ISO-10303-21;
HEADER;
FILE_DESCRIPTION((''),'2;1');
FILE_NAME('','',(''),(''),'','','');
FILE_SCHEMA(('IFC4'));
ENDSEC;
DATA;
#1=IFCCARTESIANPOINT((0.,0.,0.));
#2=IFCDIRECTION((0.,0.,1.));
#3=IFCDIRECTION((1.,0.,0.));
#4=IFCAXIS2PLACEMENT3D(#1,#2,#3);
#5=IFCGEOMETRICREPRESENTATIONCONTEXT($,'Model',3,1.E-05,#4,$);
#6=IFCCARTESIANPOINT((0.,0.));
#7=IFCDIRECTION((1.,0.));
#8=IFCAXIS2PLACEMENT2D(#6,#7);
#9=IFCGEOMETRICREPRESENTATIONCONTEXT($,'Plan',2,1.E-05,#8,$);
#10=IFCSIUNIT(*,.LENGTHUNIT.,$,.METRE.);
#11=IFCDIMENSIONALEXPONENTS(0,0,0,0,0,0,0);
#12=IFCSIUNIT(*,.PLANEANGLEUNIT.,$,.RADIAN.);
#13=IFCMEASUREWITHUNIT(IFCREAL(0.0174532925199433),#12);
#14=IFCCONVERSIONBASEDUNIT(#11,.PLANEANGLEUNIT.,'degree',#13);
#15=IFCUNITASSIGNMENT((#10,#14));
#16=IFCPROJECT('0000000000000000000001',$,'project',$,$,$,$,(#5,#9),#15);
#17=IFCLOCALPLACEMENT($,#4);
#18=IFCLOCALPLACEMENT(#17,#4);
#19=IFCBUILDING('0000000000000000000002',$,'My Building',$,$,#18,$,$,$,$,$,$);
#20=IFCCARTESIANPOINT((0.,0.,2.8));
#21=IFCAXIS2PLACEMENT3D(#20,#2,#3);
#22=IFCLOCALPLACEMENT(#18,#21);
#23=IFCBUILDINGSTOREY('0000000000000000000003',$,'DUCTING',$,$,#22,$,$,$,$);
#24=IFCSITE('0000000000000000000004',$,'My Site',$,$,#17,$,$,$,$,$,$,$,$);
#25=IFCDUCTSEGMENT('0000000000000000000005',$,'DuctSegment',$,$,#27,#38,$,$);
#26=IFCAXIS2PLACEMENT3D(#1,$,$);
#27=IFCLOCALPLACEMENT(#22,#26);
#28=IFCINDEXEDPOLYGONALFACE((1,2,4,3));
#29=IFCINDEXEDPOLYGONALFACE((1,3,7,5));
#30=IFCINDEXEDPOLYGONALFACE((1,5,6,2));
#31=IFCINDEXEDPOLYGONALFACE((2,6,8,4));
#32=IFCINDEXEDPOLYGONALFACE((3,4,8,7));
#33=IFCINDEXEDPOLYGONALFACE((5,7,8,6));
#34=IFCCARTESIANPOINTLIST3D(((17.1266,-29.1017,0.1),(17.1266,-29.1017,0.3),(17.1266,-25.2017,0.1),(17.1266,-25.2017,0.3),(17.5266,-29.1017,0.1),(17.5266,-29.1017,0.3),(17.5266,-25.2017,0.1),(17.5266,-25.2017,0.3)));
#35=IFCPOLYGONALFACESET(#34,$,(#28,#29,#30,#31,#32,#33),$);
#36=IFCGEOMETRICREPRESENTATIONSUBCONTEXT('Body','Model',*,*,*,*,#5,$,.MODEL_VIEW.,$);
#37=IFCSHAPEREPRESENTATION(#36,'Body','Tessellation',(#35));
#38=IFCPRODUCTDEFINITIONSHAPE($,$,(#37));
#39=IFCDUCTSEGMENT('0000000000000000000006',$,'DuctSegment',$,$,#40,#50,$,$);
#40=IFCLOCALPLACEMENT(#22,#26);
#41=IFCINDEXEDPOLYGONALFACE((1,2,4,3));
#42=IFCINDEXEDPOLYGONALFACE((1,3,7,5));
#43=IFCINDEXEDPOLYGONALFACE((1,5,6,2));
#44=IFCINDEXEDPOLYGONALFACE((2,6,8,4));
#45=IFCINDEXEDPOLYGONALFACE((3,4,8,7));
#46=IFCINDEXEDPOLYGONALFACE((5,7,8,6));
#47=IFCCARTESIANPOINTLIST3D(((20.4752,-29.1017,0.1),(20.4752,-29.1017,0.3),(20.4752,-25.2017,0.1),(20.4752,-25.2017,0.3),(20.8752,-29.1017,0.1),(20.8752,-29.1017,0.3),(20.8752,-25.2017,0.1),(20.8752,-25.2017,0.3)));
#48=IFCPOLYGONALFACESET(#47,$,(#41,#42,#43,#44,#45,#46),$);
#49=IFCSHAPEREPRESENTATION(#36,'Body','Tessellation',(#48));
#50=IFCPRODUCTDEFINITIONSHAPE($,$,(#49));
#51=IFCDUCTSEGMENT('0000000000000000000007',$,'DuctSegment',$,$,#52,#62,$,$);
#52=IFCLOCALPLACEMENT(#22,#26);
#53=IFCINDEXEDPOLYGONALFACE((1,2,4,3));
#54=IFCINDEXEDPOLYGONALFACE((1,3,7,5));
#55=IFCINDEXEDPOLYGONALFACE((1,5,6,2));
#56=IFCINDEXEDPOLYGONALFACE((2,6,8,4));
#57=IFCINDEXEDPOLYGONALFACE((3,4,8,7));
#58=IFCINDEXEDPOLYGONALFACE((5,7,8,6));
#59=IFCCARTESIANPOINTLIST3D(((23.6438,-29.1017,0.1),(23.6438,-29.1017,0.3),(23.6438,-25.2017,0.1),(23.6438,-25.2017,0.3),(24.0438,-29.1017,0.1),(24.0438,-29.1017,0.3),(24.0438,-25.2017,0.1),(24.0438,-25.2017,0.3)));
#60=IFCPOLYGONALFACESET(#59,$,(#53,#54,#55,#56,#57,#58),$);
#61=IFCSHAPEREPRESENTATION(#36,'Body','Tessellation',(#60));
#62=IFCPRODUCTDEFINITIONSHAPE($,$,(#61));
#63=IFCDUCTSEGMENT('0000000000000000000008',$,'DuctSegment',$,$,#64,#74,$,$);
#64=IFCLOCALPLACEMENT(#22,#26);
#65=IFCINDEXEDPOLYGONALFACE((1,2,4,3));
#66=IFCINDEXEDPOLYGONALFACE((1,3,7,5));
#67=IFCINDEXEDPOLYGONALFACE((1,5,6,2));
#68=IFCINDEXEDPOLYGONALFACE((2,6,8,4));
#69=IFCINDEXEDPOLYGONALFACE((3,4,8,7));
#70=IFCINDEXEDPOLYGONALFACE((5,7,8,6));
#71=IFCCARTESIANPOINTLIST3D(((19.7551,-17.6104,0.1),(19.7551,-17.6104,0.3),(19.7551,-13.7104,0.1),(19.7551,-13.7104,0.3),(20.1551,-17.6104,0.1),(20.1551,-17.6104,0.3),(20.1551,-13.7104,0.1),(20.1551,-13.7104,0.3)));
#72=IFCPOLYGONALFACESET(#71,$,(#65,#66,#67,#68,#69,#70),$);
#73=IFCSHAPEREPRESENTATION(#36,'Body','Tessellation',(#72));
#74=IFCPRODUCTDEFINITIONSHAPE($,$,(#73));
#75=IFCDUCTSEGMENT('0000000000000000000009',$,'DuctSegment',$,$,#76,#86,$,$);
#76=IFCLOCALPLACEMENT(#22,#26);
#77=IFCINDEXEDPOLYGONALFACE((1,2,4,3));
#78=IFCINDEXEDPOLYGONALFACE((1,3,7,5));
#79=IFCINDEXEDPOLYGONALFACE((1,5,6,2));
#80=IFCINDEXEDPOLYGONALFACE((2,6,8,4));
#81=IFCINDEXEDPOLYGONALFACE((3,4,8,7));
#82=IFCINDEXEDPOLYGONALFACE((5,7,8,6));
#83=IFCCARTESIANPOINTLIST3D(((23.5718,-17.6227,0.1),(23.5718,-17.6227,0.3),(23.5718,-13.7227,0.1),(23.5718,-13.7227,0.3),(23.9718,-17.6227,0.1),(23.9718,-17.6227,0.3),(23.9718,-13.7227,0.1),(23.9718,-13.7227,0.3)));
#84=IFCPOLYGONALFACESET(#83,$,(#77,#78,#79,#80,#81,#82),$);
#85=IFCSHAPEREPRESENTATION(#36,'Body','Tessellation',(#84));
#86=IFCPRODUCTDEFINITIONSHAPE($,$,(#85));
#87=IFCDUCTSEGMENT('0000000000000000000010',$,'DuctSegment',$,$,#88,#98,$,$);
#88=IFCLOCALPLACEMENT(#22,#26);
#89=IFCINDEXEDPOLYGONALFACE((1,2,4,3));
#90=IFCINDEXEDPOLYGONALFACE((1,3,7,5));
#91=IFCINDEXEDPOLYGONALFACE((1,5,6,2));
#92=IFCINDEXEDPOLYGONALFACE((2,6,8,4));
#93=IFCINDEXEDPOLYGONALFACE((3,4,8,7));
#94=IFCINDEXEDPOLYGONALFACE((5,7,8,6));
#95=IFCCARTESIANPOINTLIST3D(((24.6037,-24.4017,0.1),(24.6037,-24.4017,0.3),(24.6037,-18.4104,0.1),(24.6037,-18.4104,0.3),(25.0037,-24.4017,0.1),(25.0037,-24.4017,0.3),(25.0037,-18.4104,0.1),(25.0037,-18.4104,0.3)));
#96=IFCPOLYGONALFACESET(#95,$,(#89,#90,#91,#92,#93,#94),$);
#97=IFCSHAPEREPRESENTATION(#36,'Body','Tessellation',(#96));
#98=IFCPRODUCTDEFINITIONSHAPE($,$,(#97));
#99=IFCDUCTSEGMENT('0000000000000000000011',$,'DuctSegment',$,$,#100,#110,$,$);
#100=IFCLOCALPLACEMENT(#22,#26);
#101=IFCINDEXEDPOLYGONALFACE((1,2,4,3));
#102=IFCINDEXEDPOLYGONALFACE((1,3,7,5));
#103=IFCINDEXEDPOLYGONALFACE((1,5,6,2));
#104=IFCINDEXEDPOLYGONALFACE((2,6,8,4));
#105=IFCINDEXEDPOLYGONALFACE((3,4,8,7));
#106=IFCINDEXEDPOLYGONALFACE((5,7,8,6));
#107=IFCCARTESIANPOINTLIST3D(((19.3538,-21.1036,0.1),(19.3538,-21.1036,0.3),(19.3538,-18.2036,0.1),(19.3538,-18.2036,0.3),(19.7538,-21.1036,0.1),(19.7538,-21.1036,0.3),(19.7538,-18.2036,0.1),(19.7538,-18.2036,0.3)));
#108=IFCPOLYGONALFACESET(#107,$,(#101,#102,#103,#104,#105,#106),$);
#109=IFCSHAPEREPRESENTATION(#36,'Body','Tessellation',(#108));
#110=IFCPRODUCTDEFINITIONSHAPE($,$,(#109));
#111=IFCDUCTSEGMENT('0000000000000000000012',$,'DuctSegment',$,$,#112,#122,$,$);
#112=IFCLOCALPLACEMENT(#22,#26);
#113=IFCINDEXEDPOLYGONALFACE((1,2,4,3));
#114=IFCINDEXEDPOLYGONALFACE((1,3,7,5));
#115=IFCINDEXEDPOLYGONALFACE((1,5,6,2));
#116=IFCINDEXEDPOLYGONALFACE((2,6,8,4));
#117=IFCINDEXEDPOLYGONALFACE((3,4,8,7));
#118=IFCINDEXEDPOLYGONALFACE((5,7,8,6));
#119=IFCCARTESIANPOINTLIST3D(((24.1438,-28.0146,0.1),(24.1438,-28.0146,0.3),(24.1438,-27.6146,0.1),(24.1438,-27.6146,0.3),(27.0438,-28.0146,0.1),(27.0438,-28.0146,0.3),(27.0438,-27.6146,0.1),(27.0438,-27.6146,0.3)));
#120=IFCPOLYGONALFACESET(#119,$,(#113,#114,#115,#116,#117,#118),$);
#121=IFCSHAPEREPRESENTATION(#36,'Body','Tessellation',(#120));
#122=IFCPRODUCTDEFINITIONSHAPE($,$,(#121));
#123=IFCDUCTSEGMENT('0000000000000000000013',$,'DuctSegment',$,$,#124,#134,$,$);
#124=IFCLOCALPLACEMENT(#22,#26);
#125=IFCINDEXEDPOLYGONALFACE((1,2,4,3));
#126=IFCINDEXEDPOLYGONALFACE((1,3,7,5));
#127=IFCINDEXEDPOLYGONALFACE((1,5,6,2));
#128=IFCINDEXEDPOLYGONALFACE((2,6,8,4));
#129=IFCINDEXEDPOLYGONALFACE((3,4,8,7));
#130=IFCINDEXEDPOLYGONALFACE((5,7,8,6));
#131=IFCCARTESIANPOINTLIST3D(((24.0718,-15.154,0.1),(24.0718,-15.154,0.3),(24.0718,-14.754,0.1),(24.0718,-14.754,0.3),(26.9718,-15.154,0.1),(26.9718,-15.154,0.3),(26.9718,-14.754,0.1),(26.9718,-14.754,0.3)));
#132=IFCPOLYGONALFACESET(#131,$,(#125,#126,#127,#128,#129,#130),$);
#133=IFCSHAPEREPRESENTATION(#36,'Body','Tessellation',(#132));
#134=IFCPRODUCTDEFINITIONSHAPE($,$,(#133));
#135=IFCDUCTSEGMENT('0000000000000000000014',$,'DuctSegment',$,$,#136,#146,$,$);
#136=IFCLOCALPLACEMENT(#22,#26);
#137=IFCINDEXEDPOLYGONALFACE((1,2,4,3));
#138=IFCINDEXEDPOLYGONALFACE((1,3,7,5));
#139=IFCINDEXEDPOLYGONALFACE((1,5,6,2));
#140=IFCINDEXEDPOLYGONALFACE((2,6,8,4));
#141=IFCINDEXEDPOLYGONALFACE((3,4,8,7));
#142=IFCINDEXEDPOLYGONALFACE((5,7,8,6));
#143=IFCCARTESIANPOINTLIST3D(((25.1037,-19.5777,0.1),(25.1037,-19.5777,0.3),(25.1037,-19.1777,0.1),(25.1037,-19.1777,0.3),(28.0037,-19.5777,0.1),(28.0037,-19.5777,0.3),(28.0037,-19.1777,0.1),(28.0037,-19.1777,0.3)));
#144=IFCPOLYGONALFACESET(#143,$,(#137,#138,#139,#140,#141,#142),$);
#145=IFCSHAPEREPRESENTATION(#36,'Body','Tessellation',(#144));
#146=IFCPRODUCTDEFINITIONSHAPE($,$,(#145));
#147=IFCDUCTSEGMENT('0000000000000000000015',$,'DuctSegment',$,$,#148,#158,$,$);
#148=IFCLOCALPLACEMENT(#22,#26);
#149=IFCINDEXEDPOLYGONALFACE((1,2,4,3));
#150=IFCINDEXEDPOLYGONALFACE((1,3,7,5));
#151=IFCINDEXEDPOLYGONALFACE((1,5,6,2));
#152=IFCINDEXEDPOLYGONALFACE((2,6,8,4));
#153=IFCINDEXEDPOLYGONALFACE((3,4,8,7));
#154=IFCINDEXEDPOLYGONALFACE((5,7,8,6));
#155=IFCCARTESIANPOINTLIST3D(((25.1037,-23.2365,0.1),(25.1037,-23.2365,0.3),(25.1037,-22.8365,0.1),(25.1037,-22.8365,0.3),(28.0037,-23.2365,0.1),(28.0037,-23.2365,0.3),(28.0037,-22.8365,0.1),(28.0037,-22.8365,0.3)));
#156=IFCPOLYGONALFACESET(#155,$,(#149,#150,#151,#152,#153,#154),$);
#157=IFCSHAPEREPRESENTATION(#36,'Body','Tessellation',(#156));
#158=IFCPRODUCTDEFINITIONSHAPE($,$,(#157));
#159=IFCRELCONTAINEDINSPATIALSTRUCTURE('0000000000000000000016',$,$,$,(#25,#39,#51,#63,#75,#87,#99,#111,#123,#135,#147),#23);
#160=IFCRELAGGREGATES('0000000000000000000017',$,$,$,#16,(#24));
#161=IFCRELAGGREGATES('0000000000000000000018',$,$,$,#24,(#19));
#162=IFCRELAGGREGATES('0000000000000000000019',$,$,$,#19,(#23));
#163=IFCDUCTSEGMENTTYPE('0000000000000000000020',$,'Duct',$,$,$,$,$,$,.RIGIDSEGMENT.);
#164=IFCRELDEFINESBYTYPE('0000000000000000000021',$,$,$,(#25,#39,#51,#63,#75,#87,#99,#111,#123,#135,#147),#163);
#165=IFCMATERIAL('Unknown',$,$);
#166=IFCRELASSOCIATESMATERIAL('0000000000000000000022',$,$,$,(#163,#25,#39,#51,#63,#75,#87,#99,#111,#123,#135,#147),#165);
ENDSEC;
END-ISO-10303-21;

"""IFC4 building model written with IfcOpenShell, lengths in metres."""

from ifc_helpers import new_model, entity, si_unit, converted_unit, frame, origin_with_axes, origin_2d_with_axis, place, context, subcontext, project, spatial, rectangle, extrude, material, material_profile, profile_set, profile_usage, type_object, element, save


model = new_model("IFC4")

# Units and contexts
model_context = context("Model", 3, precision=1e-05, world=origin_with_axes())
plan_context = context("Plan", 2, precision=1e-05, world=origin_2d_with_axis())
body_context = subcontext(model_context, "Body", "Model", "MODEL_VIEW")
ifc_project = project(units=[si_unit("LENGTHUNIT", "METRE"), converted_unit("PLANEANGLEUNIT", "degree", entity("IfcReal", 0.0174532925199433), si_unit("PLANEANGLEUNIT", "RADIAN"), dimensions=[0, 0, 0, 0, 0, 0, 0])], contexts=[model_context, plan_context])

# Site, building, storey
site_placement = place(None, origin_with_axes())
site = spatial("IfcSite", under=ifc_project, at=site_placement, Name="My Site")
building_placement = place(site_placement, origin_with_axes())
building = spatial("IfcBuilding", under=site, at=building_placement, Name="My Building")
storey_placement = place(building_placement, frame((0.0, 0.0, 2.8), z_axis=(0.0, 0.0, 1.0), x_axis=(1.0, 0.0, 0.0)))
storey = spatial("IfcBuildingStorey", under=building, at=storey_placement, Name="DUCTING")

# Duct segments
ifc_material = material(Name="Unknown")
ifc_material_profile_1 = material_profile(ifc_material, rectangle(XDim=0.4, YDim=0.2))
ifc_profile_set_1 = profile_set([ifc_material_profile_1])
ifc_profile_usage_1 = profile_usage(ifc_profile_set_1, cardinal=5)
duct_segment_type = type_object("IfcDuctSegmentType", Name="Duct", PredefinedType="RIGIDSEGMENT", material=ifc_profile_set_1)
duct_segment_1_placement = place(storey_placement, frame((17.3266, -25.2017, 0.2), z_axis=(0.0, -1.0, 0.0), x_axis=(1.0, 0.0, 0.0)))
element("IfcDuctSegment", 1, at=duct_segment_1_placement, inside=storey, type_object=duct_segment_type, material=ifc_profile_usage_1, Name="DuctSegment", context=body_context, shape_type="SweptSolid", body=[
    extrude(rectangle(XDim=0.4, YDim=0.2), origin_with_axes(), (0.0, 0.0, 1.0), 3.9),
])
ifc_profile_usage_2 = profile_usage(ifc_profile_set_1, cardinal=5)
duct_segment_2_placement = place(storey_placement, frame((20.6752, -25.2017, 0.2), z_axis=(0.0, -1.0, 0.0), x_axis=(1.0, 0.0, 0.0)))
element("IfcDuctSegment", 2, at=duct_segment_2_placement, inside=storey, type_object=duct_segment_type, material=ifc_profile_usage_2, Name="DuctSegment", context=body_context, shape_type="SweptSolid", body=[
    extrude(rectangle(XDim=0.4, YDim=0.2), origin_with_axes(), (0.0, 0.0, 1.0), 3.9),
])
ifc_profile_usage_3 = profile_usage(ifc_profile_set_1, cardinal=5)
duct_segment_3_placement = place(storey_placement, frame((23.8438, -25.2017, 0.2), z_axis=(0.0, -1.0, 0.0), x_axis=(1.0, 0.0, 0.0)))
element("IfcDuctSegment", 3, at=duct_segment_3_placement, inside=storey, type_object=duct_segment_type, material=ifc_profile_usage_3, Name="DuctSegment", context=body_context, shape_type="SweptSolid", body=[
    extrude(rectangle(XDim=0.4, YDim=0.2), origin_with_axes(), (0.0, 0.0, 1.0), 3.9),
])
ifc_profile_usage_4 = profile_usage(ifc_profile_set_1, cardinal=5)
duct_segment_4_placement = place(storey_placement, frame((19.9551, -17.6104, 0.2), z_axis=(0.0, 1.0, 0.0), x_axis=(1.0, 0.0, 0.0)))
element("IfcDuctSegment", 4, at=duct_segment_4_placement, inside=storey, type_object=duct_segment_type, material=ifc_profile_usage_4, Name="DuctSegment", context=body_context, shape_type="SweptSolid", body=[
    extrude(rectangle(XDim=0.4, YDim=0.2), origin_with_axes(), (0.0, 0.0, 1.0), 3.9),
])
ifc_profile_usage_5 = profile_usage(ifc_profile_set_1, cardinal=5)
duct_segment_5_placement = place(storey_placement, frame((23.7718, -17.6227, 0.2), z_axis=(0.0, 1.0, 0.0), x_axis=(1.0, 0.0, 0.0)))
element("IfcDuctSegment", 5, at=duct_segment_5_placement, inside=storey, type_object=duct_segment_type, material=ifc_profile_usage_5, Name="DuctSegment", context=body_context, shape_type="SweptSolid", body=[
    extrude(rectangle(XDim=0.4, YDim=0.2), origin_with_axes(), (0.0, 0.0, 1.0), 3.9),
])
ifc_profile_usage_6 = profile_usage(ifc_profile_set_1, cardinal=5)
duct_segment_6_placement = place(storey_placement, frame((24.8037, -18.4104, 0.2), z_axis=(0.0, -1.0, 0.0), x_axis=(1.0, 0.0, 0.0)))
element("IfcDuctSegment", 6, at=duct_segment_6_placement, inside=storey, type_object=duct_segment_type, material=ifc_profile_usage_6, Name="DuctSegment", context=body_context, shape_type="SweptSolid", body=[
    extrude(rectangle(XDim=0.4, YDim=0.2), origin_with_axes(), (0.0, 0.0, 1.0), 5.9913),
])
ifc_profile_usage_7 = profile_usage(ifc_profile_set_1, cardinal=5)
duct_segment_7_placement = place(storey_placement, frame((19.5538, -18.2036, 0.2), z_axis=(0.0, -1.0, 0.0), x_axis=(1.0, 0.0, 0.0)))
element("IfcDuctSegment", 7, at=duct_segment_7_placement, inside=storey, type_object=duct_segment_type, material=ifc_profile_usage_7, Name="DuctSegment", context=body_context, shape_type="SweptSolid", body=[
    extrude(rectangle(XDim=0.4, YDim=0.2), origin_with_axes(), (0.0, 0.0, 1.0), 2.9),
])
ifc_profile_usage_8 = profile_usage(ifc_profile_set_1, cardinal=5)
duct_segment_8_placement = place(storey_placement, frame((24.1438, -27.8146, 0.2), z_axis=(1.0, 0.0, 0.0), x_axis=(0.0, 1.0, 0.0)))
element("IfcDuctSegment", 8, at=duct_segment_8_placement, inside=storey, type_object=duct_segment_type, material=ifc_profile_usage_8, Name="DuctSegment", context=body_context, shape_type="SweptSolid", body=[
    extrude(rectangle(XDim=0.4, YDim=0.2), origin_with_axes(), (0.0, 0.0, 1.0), 2.9),
])
ifc_profile_usage_9 = profile_usage(ifc_profile_set_1, cardinal=5)
duct_segment_9_placement = place(storey_placement, frame((24.0718, -14.954, 0.2), z_axis=(1.0, 0.0, 0.0), x_axis=(0.0, 1.0, 0.0)))
element("IfcDuctSegment", 9, at=duct_segment_9_placement, inside=storey, type_object=duct_segment_type, material=ifc_profile_usage_9, Name="DuctSegment", context=body_context, shape_type="SweptSolid", body=[
    extrude(rectangle(XDim=0.4, YDim=0.2), origin_with_axes(), (0.0, 0.0, 1.0), 2.9),
])
ifc_profile_usage_10 = profile_usage(ifc_profile_set_1, cardinal=5)
duct_segment_10_placement = place(storey_placement, frame((25.1037, -19.3777, 0.2), z_axis=(1.0, 0.0, 0.0), x_axis=(0.0, 1.0, 0.0)))
element("IfcDuctSegment", 10, at=duct_segment_10_placement, inside=storey, type_object=duct_segment_type, material=ifc_profile_usage_10, Name="DuctSegment", context=body_context, shape_type="SweptSolid", body=[
    extrude(rectangle(XDim=0.4, YDim=0.2), origin_with_axes(), (0.0, 0.0, 1.0), 2.9),
])
ifc_profile_usage_11 = profile_usage(ifc_profile_set_1, cardinal=5)
duct_segment_11_placement = place(storey_placement, frame((25.1037, -23.0365, 0.2), z_axis=(1.0, 0.0, 0.0), x_axis=(0.0, 1.0, 0.0)))
element("IfcDuctSegment", 11, at=duct_segment_11_placement, inside=storey, type_object=duct_segment_type, material=ifc_profile_usage_11, Name="DuctSegment", context=body_context, shape_type="SweptSolid", body=[
    extrude(rectangle(XDim=0.4, YDim=0.2), origin_with_axes(), (0.0, 0.0, 1.0), 2.9),
])

save(model, "model.ifc")
